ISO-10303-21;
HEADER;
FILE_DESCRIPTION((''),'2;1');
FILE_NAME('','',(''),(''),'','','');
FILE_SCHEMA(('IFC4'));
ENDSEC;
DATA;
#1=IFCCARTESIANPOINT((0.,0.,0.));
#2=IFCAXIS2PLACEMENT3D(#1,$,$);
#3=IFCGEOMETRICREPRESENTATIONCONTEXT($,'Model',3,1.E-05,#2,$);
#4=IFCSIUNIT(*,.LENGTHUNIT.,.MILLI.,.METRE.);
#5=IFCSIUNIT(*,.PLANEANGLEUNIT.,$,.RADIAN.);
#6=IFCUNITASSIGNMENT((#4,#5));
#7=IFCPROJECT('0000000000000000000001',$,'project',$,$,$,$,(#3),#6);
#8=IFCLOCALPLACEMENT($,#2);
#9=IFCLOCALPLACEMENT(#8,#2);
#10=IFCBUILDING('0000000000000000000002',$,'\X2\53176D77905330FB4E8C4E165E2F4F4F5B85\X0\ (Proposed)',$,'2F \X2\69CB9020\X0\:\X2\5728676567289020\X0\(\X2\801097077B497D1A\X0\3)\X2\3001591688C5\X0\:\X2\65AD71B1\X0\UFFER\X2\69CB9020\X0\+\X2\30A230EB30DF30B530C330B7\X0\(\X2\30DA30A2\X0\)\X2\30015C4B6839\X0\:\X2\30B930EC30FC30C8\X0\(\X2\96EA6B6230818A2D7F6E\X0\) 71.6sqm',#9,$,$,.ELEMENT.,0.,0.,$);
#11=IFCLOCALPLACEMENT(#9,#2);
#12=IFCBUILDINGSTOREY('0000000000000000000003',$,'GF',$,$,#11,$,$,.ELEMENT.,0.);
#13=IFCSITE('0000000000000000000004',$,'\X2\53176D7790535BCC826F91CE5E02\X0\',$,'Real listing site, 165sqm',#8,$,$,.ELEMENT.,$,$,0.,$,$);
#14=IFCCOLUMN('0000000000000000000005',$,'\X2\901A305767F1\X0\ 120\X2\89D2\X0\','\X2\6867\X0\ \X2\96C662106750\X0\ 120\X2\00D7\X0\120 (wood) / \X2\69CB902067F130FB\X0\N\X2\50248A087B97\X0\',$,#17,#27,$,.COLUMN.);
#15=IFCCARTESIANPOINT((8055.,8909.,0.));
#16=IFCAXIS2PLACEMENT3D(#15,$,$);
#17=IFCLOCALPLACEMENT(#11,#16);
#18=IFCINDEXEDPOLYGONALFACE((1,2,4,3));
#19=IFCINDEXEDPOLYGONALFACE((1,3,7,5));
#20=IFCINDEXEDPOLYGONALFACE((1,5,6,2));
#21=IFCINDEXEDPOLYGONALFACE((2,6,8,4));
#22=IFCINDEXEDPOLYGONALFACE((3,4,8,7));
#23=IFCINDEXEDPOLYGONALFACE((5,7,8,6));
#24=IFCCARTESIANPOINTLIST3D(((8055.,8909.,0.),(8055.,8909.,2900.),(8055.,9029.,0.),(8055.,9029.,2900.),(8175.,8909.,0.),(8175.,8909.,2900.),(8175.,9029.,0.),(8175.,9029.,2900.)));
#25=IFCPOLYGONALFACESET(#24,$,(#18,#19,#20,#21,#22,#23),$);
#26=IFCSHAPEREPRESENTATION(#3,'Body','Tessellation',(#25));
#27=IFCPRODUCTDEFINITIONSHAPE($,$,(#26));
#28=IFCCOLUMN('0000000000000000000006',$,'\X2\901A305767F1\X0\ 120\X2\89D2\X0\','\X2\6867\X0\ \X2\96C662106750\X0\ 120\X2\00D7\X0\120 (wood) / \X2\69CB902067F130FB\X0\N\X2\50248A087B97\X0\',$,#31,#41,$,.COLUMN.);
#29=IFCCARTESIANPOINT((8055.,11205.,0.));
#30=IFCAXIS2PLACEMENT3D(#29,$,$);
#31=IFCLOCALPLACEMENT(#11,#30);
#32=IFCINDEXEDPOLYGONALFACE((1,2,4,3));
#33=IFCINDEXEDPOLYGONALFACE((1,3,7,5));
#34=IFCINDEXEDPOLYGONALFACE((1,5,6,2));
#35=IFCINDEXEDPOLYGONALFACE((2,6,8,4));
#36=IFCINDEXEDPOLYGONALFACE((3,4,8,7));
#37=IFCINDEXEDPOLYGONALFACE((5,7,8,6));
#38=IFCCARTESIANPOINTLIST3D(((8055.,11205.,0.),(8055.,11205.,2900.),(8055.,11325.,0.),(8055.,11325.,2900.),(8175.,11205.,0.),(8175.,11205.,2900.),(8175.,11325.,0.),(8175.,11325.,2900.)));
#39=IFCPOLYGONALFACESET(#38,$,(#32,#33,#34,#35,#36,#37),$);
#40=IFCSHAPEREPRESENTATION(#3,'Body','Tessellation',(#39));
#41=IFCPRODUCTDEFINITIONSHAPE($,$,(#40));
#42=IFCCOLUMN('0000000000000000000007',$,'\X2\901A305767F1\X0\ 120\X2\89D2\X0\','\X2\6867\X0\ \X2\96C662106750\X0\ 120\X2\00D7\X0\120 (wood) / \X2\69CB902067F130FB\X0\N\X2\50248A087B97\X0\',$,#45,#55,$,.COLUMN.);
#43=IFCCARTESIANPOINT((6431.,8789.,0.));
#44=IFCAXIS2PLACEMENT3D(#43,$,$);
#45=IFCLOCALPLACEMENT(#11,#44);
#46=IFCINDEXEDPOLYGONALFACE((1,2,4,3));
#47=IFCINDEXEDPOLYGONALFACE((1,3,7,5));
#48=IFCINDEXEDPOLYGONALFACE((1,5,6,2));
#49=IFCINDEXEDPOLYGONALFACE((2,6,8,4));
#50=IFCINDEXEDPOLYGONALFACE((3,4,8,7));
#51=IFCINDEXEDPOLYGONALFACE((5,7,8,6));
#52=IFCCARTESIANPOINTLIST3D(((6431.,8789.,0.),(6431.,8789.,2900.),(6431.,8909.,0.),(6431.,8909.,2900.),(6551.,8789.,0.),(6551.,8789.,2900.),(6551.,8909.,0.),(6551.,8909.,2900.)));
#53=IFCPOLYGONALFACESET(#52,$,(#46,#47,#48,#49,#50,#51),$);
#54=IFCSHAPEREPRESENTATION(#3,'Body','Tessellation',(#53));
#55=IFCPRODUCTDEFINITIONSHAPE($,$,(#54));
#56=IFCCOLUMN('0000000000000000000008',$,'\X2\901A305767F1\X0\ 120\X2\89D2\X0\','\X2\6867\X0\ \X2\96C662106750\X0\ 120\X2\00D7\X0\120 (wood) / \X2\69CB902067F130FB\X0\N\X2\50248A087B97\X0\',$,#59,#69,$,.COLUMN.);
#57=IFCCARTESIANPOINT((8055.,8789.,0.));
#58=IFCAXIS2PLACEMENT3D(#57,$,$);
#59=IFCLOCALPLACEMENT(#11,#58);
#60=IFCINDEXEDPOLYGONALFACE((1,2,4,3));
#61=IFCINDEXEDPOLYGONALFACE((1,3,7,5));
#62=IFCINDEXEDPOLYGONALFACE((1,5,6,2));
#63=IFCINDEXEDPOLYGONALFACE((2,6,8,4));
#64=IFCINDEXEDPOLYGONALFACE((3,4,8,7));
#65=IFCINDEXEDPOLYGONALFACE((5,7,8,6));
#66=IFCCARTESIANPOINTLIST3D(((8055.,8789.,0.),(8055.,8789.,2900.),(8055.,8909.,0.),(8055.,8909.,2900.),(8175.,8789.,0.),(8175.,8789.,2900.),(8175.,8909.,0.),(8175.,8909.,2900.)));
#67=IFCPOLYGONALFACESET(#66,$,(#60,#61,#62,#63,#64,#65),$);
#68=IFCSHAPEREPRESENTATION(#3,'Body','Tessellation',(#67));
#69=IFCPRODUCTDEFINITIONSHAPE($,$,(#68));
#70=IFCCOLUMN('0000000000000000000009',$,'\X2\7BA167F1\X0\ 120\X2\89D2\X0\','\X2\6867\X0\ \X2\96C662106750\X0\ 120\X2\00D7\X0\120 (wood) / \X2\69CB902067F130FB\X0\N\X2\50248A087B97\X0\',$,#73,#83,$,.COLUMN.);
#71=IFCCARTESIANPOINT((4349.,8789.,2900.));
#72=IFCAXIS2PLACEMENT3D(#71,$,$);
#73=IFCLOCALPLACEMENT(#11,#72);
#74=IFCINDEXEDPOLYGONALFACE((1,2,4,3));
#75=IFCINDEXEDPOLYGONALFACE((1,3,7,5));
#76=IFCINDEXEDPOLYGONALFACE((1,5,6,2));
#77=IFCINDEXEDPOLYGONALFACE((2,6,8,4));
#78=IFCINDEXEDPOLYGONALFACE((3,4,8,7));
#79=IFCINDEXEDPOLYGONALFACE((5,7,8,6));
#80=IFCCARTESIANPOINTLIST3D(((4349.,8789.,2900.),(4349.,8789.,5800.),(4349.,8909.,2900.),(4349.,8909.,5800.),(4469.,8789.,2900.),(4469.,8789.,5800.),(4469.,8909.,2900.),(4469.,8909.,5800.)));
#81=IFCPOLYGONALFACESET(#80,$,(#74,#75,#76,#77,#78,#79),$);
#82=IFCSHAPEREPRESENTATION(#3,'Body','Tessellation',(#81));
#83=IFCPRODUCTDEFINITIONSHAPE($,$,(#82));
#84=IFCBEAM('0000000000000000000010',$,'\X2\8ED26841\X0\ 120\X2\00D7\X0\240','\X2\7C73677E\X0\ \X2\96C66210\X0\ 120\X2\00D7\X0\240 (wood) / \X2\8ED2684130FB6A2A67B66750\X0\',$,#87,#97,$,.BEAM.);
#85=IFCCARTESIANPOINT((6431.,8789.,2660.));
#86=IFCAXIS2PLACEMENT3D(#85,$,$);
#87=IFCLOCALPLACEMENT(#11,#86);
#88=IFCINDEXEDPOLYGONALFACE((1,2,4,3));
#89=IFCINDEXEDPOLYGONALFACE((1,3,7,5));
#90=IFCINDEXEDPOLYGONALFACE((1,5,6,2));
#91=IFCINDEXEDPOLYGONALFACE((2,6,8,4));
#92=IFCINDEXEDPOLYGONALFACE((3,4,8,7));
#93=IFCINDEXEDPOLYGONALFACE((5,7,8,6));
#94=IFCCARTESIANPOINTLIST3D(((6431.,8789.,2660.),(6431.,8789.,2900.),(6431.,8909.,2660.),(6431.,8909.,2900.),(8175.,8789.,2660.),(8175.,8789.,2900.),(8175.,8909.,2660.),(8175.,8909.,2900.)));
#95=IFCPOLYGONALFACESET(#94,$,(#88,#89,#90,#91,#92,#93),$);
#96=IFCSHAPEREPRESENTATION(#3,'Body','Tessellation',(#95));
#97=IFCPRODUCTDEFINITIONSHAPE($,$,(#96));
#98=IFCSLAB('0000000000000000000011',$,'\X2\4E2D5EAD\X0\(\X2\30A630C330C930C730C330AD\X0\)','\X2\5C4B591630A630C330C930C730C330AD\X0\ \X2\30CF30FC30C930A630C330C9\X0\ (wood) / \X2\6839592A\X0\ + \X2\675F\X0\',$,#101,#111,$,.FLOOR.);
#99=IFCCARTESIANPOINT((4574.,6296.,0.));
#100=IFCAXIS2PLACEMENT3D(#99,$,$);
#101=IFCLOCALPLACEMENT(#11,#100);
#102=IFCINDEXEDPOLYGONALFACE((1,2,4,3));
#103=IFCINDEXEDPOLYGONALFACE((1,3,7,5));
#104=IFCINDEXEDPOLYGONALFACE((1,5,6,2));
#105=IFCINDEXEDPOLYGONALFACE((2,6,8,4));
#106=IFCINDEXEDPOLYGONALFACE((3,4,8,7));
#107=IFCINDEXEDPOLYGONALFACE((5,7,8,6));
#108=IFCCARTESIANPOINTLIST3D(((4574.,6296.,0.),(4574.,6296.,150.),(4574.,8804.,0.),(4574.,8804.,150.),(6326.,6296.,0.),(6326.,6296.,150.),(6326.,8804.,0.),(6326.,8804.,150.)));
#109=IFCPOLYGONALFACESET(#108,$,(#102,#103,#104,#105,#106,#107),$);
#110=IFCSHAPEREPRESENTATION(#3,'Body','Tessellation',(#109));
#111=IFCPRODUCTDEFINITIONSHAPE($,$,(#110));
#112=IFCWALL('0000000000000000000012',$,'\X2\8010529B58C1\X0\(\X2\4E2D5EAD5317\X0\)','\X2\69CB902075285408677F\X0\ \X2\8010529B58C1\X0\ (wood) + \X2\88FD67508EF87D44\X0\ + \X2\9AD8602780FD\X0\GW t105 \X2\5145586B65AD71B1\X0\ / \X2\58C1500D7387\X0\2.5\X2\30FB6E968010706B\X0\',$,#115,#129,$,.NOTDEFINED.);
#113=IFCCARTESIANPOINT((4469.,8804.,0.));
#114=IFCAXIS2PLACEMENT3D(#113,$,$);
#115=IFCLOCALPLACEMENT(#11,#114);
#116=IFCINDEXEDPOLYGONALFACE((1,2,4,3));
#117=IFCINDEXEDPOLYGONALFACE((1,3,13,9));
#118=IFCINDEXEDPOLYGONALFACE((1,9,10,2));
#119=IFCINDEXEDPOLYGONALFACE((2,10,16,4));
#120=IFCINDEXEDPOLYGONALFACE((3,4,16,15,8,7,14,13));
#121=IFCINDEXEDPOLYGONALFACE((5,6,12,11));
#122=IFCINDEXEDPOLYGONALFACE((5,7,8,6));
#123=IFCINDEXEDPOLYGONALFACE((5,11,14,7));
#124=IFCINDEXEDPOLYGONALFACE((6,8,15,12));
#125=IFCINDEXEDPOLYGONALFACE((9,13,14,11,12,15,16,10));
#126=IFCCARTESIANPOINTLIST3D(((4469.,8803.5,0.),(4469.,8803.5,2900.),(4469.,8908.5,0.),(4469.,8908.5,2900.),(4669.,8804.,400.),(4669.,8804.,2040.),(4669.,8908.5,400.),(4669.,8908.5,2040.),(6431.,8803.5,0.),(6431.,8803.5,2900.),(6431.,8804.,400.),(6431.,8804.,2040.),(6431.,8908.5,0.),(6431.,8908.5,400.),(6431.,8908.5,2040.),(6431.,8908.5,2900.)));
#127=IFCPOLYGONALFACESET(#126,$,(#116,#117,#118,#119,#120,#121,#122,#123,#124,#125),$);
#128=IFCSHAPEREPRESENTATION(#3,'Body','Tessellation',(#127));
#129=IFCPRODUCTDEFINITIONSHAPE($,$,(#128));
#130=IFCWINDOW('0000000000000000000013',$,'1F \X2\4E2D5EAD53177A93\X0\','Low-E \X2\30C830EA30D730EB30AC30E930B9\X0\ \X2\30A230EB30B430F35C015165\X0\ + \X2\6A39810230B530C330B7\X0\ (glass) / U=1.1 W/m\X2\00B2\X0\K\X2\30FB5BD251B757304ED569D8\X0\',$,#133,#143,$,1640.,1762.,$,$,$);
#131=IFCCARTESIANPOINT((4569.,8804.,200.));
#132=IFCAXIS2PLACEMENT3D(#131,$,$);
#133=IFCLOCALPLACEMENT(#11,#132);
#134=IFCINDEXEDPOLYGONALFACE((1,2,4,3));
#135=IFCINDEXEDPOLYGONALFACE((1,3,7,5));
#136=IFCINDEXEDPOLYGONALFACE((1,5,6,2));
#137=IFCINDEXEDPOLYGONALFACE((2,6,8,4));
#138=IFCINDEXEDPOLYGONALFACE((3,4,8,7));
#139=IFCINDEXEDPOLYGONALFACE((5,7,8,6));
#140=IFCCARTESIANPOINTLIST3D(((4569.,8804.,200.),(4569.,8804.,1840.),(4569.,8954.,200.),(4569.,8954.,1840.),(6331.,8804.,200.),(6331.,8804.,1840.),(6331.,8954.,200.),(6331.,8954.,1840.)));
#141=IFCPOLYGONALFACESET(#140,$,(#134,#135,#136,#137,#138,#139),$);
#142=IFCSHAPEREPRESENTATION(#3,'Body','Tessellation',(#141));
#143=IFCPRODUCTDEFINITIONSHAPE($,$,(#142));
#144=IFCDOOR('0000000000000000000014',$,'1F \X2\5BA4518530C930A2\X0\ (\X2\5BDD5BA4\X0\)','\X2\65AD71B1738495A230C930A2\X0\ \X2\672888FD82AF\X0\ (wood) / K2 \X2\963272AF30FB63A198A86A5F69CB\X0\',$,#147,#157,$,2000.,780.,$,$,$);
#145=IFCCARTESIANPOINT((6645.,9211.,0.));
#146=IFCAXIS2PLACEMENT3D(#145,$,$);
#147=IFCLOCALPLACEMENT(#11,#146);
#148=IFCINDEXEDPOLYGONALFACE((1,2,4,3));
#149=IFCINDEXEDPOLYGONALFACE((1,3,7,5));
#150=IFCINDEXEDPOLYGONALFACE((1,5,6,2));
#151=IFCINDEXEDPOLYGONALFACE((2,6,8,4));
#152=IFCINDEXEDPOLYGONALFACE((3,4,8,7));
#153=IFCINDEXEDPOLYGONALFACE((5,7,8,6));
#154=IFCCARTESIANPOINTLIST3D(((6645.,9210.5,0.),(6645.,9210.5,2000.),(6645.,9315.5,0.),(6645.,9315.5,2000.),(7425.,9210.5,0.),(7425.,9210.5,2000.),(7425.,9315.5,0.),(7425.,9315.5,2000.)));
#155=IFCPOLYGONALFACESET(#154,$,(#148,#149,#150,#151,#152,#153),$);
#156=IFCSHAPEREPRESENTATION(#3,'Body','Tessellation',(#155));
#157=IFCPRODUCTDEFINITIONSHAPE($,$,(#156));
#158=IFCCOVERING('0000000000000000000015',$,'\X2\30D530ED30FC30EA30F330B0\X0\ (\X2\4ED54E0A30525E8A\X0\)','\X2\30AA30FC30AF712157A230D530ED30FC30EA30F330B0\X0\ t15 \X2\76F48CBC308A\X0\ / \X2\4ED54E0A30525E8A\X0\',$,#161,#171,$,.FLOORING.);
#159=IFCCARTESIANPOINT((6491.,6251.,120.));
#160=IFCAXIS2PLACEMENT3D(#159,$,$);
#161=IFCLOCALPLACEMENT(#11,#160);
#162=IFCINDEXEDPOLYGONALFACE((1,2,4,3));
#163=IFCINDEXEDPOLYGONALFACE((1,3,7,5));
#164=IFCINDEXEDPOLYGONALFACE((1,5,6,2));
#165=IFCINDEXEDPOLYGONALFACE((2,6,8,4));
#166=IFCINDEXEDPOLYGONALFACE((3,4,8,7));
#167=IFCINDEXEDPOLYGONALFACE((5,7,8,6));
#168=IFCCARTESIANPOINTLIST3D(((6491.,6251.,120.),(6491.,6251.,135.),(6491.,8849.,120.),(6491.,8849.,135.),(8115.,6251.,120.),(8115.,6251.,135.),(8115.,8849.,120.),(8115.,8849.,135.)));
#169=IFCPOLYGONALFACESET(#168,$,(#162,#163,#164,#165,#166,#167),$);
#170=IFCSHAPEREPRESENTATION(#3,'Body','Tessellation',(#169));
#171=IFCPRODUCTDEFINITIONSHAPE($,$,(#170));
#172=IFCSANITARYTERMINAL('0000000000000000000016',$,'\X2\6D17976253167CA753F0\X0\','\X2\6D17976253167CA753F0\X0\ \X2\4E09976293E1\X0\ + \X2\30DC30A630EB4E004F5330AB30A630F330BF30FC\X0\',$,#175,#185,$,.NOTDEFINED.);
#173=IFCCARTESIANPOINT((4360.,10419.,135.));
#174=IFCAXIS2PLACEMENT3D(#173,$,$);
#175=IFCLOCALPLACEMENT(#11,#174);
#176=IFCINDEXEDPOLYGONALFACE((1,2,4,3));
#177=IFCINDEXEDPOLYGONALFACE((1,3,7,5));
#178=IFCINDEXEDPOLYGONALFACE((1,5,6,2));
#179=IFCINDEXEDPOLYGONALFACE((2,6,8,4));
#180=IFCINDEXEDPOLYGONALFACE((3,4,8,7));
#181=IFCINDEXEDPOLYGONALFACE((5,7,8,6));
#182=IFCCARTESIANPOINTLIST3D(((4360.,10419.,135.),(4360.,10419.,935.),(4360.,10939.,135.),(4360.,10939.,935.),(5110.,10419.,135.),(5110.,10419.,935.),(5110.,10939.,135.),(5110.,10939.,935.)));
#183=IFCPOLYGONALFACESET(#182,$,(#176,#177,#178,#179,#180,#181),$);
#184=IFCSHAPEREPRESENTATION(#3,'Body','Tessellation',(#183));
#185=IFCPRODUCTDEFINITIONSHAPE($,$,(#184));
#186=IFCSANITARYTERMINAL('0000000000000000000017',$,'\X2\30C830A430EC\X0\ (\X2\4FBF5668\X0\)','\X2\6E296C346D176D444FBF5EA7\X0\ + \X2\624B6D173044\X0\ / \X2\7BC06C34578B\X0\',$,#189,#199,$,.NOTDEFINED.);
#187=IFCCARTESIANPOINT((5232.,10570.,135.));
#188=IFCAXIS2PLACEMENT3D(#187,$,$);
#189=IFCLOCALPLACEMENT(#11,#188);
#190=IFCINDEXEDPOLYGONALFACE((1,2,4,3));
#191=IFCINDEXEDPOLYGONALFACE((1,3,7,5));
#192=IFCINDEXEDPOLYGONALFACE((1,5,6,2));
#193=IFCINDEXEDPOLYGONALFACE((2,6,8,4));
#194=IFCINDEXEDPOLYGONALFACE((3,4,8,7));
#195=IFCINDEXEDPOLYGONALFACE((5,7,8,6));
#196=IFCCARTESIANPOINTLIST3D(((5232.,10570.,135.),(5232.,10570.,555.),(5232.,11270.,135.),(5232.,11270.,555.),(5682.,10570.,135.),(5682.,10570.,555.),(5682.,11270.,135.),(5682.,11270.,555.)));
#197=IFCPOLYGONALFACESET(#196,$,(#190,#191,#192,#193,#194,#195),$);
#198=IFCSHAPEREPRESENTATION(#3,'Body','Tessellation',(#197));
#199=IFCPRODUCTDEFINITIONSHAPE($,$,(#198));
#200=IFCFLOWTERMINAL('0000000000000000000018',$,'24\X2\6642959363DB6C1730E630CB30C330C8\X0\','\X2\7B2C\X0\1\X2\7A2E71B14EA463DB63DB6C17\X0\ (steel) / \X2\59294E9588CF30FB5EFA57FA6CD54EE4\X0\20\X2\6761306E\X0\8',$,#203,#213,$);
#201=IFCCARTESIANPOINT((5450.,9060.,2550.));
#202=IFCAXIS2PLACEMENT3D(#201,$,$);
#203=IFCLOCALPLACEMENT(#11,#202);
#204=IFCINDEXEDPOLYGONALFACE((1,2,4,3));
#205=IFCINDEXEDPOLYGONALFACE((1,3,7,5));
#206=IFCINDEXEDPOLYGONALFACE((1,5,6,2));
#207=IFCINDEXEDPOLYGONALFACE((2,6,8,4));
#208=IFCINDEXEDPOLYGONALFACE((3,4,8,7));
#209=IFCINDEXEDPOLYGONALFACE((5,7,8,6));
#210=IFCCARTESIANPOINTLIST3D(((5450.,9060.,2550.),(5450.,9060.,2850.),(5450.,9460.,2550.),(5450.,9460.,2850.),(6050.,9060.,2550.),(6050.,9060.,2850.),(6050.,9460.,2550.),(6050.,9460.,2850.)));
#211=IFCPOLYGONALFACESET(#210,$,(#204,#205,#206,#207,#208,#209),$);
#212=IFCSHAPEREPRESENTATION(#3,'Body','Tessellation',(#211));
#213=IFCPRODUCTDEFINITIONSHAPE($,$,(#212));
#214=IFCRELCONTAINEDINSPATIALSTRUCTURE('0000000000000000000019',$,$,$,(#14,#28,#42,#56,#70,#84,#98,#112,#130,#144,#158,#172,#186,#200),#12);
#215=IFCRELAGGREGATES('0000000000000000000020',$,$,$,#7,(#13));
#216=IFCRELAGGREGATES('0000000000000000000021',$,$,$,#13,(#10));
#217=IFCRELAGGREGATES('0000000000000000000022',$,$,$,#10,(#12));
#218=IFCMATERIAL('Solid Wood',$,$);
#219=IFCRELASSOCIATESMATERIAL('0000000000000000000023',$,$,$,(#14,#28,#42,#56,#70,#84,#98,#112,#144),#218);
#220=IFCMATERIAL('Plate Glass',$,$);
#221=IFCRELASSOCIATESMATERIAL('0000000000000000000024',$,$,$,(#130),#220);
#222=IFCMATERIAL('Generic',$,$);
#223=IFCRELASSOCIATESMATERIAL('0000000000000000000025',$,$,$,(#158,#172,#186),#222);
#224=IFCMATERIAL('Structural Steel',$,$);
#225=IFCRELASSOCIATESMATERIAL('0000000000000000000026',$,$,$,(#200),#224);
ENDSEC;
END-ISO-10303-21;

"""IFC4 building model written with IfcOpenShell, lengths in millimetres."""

from ifc_helpers import new_model, si_unit, frame, frame_2d, origin, place, context, project, spatial, rectangle, extrude, material, element, fill, save


model = new_model("IFC4")

# Units and contexts
model_context = context("Model", 3, precision=1e-05, world=origin())
ifc_project = project(units=[si_unit("LENGTHUNIT", "METRE", prefix="MILLI"), si_unit("PLANEANGLEUNIT", "RADIAN")], contexts=[model_context])

# Site, building, storey
site_placement = place(None, origin())
site = spatial("IfcSite", under=ifc_project, at=site_placement, Name="北海道富良野市", ObjectType="Real listing site, 165sqm", CompositionType="ELEMENT", RefElevation=0.0)
building_placement = place(site_placement, origin())
building = spatial("IfcBuilding", under=site, at=building_placement, Name="北海道・二世帯住宅 (Proposed)", ObjectType="2F 構造:在来木造(耐震等級3)、外装:断熱UFFER構造+アルミサッシ(ペア)、屋根:スレート(雪止め設置) 71.6sqm", CompositionType="ELEMENT", ElevationOfRefHeight=0.0, ElevationOfTerrain=0.0)
storey_placement = place(building_placement, origin())
storey = spatial("IfcBuildingStorey", under=building, at=storey_placement, Name="GF", CompositionType="ELEMENT", Elevation=0.0)

# Columns
ifc_material_1 = material(Name="Solid Wood")
column_1_placement = place(storey_placement, frame((8055.0, 8909.0, 0.0)))
element("IfcColumn", 1, at=column_1_placement, inside=storey, material=ifc_material_1, Name="通し柱 120角", Description="桧 集成材 120×120 (wood) / 構造柱・N値計算", PredefinedType="COLUMN", context=model_context, shape_type="SweptSolid", body=[
    extrude(rectangle(XDim=120.0, YDim=120.0, at=frame_2d((60.0, 60.0))), frame((8055.0, 8909.0, 0.0)), (0.0, 0.0, 1.0), 2900.0),
])
column_2_placement = place(storey_placement, frame((8055.0, 11205.0, 0.0)))
element("IfcColumn", 2, at=column_2_placement, inside=storey, material=ifc_material_1, Name="通し柱 120角", Description="桧 集成材 120×120 (wood) / 構造柱・N値計算", PredefinedType="COLUMN", context=model_context, shape_type="SweptSolid", body=[
    extrude(rectangle(XDim=120.0, YDim=120.0, at=frame_2d((60.0, 60.0))), frame((8055.0, 11205.0, 0.0)), (0.0, 0.0, 1.0), 2900.0),
])
column_3_placement = place(storey_placement, frame((6431.0, 8789.0, 0.0)))
element("IfcColumn", 3, at=column_3_placement, inside=storey, material=ifc_material_1, Name="通し柱 120角", Description="桧 集成材 120×120 (wood) / 構造柱・N値計算", PredefinedType="COLUMN", context=model_context, shape_type="SweptSolid", body=[
    extrude(rectangle(XDim=120.0, YDim=120.0, at=frame_2d((60.0, 60.0))), frame((6431.0, 8789.0, 0.0)), (0.0, 0.0, 1.0), 2900.0),
])
column_4_placement = place(storey_placement, frame((8055.0, 8789.0, 0.0)))
element("IfcColumn", 4, at=column_4_placement, inside=storey, material=ifc_material_1, Name="通し柱 120角", Description="桧 集成材 120×120 (wood) / 構造柱・N値計算", PredefinedType="COLUMN", context=model_context, shape_type="SweptSolid", body=[
    extrude(rectangle(XDim=120.0, YDim=120.0, at=frame_2d((60.0, 60.0))), frame((8055.0, 8789.0, 0.0)), (0.0, 0.0, 1.0), 2900.0),
])
column_5_placement = place(storey_placement, frame((4349.0, 8789.0, 2900.0)))
element("IfcColumn", 5, at=column_5_placement, inside=storey, material=ifc_material_1, Name="管柱 120角", Description="桧 集成材 120×120 (wood) / 構造柱・N値計算", PredefinedType="COLUMN", context=model_context, shape_type="SweptSolid", body=[
    extrude(rectangle(XDim=120.0, YDim=120.0, at=frame_2d((60.0, 60.0))), frame((4349.0, 8789.0, 2900.0)), (0.0, 0.0, 1.0), 2900.0),
])

# Beam
beam_1_placement = place(storey_placement, frame((6431.0, 8789.0, 2660.0)))
element("IfcBeam", 6, at=beam_1_placement, inside=storey, material=ifc_material_1, Name="軒桁 120×240", Description="米松 集成 120×240 (wood) / 軒桁・横架材", PredefinedType="BEAM", context=model_context, shape_type="SweptSolid", body=[
    extrude(rectangle(XDim=1744.0, YDim=120.0, at=frame_2d((872.0, 60.0))), frame((6431.0, 8789.0, 2660.0)), (0.0, 0.0, 1.0), 240.0),
])

# Slab
slab_placement = place(storey_placement, frame((4574.0, 6296.0, 0.0)))
element("IfcSlab", 7, at=slab_placement, inside=storey, material=ifc_material_1, Name="中庭(ウッドデッキ)", Description="屋外ウッドデッキ ハードウッド (wood) / 根太 + 束", PredefinedType="FLOOR", context=model_context, shape_type="SweptSolid", body=[
    extrude(rectangle(XDim=1752.0, YDim=2508.0, at=frame_2d((876.0, 1254.0))), frame((4574.0, 6296.0, 0.0)), (0.0, 0.0, 1.0), 150.0),
])

# Wall, opening, window
wall_1_placement = place(storey_placement, frame((4469.0, 8804.0, 0.0)))
wall_1 = element("IfcWall", 8, at=wall_1_placement, inside=storey, material=ifc_material_1, Name="耐力壁(中庭北)", Description="構造用合板 耐力壁 (wood) + 製材軸組 + 高性能GW t105 充填断熱 / 壁倍率2.5・準耐火", PredefinedType="NOTDEFINED", context=model_context, shape_type="SweptSolid", body=[
    extrude(rectangle(XDim=1962.0, YDim=105.0, at=frame_2d((981.0, 52.0))), frame((4469.0, 8804.0, 0.0)), (0.0, 0.0, 1.0), 2900.0),
])
opening_placement = place(storey_placement, frame((4569.0, 8804.0, 200.0)))
opening = element("IfcOpeningElement", 9, at=opening_placement, cuts=wall_1, PredefinedType="NOTDEFINED", context=model_context, shape_type="SweptSolid", body=[
    extrude(rectangle(XDim=1762.0, YDim=150.0, at=frame_2d((881.0, 75.0))), frame((4569.0, 8804.0, 200.0)), (0.0, 0.0, 1.0), 1640.0),
])
ifc_material_2 = material(Name="Plate Glass")
window_placement = place(storey_placement, frame((4569.0, 8804.0, 200.0)))
window = element("IfcWindow", 10, at=window_placement, inside=storey, material=ifc_material_2, Name="1F 中庭北窓", Description="Low-E トリプルガラス アルゴン封入 + 樹脂サッシ (glass) / U=1.1 W/m²K・寒冷地仕様", OverallHeight=1640.0, OverallWidth=1762.0, context=model_context, shape_type="SweptSolid", body=[
    extrude(rectangle(XDim=1762.0, YDim=150.0, at=frame_2d((881.0, 75.0))), frame((4569.0, 8804.0, 200.0)), (0.0, 0.0, 1.0), 1640.0),
])
fill(opening, window)

# Door
door_placement = place(storey_placement, frame((6645.0, 9211.0, 0.0)))
element("IfcDoor", 11, at=door_placement, inside=storey, material=ifc_material_1, Name="1F 室内ドア (寝室)", Description="断熱玄関ドア 木製芯 (wood) / K2 防犯・採風機構", OverallHeight=2000.0, OverallWidth=780.0, context=model_context, shape_type="SweptSolid", body=[
    extrude(rectangle(XDim=780.0, YDim=105.0, at=frame_2d((390.0, 52.0))), frame((6645.0, 9211.0, 0.0)), (0.0, 0.0, 1.0), 2000.0),
])

# Covering
ifc_material_3 = material(Name="Generic")
covering_placement = place(storey_placement, frame((6491.0, 6251.0, 120.0)))
element("IfcCovering", 12, at=covering_placement, inside=storey, material=ifc_material_3, Name="フローリング (仕上げ床)", Description="オーク無垢フローリング t15 直貼り / 仕上げ床", PredefinedType="FLOORING", context=model_context, shape_type="SweptSolid", body=[
    extrude(rectangle(XDim=1624.0, YDim=2598.0, at=frame_2d((812.0, 1299.0))), frame((6491.0, 6251.0, 120.0)), (0.0, 0.0, 1.0), 15.0),
])

# Sanitary terminals
sanitary_terminal_1_placement = place(storey_placement, frame((4360.0, 10419.0, 135.0)))
element("IfcSanitaryTerminal", 13, at=sanitary_terminal_1_placement, inside=storey, material=ifc_material_3, Name="洗面化粧台", Description="洗面化粧台 三面鏡 + ボウル一体カウンター", PredefinedType="NOTDEFINED", context=model_context, shape_type="SweptSolid", body=[
    extrude(rectangle(XDim=750.0, YDim=520.0, at=frame_2d((375.0, 260.0))), frame((4360.0, 10419.0, 135.0)), (0.0, 0.0, 1.0), 800.0),
])
sanitary_terminal_2_placement = place(storey_placement, frame((5232.0, 10570.0, 135.0)))
element("IfcSanitaryTerminal", 14, at=sanitary_terminal_2_placement, inside=storey, material=ifc_material_3, Name="トイレ (便器)", Description="温水洗浄便座 + 手洗い / 節水型", PredefinedType="NOTDEFINED", context=model_context, shape_type="SweptSolid", body=[
    extrude(rectangle(XDim=450.0, YDim=700.0, at=frame_2d((225.0, 350.0))), frame((5232.0, 10570.0, 135.0)), (0.0, 0.0, 1.0), 420.0),
])

# Flow terminal
ifc_material_4 = material(Name="Structural Steel")
flow_terminal_placement = place(storey_placement, frame((5450.0, 9060.0, 2550.0)))
element("IfcFlowTerminal", 15, at=flow_terminal_placement, inside=storey, material=ifc_material_4, Name="24時間換気ユニット", Description="第1種熱交換換気 (steel) / 天井裏・建基法令20条の8", context=model_context, shape_type="SweptSolid", body=[
    extrude(rectangle(XDim=600.0, YDim=400.0, at=frame_2d((300.0, 200.0))), frame((5450.0, 9060.0, 2550.0)), (0.0, 0.0, 1.0), 300.0),
])

save(model, "model.ifc")
